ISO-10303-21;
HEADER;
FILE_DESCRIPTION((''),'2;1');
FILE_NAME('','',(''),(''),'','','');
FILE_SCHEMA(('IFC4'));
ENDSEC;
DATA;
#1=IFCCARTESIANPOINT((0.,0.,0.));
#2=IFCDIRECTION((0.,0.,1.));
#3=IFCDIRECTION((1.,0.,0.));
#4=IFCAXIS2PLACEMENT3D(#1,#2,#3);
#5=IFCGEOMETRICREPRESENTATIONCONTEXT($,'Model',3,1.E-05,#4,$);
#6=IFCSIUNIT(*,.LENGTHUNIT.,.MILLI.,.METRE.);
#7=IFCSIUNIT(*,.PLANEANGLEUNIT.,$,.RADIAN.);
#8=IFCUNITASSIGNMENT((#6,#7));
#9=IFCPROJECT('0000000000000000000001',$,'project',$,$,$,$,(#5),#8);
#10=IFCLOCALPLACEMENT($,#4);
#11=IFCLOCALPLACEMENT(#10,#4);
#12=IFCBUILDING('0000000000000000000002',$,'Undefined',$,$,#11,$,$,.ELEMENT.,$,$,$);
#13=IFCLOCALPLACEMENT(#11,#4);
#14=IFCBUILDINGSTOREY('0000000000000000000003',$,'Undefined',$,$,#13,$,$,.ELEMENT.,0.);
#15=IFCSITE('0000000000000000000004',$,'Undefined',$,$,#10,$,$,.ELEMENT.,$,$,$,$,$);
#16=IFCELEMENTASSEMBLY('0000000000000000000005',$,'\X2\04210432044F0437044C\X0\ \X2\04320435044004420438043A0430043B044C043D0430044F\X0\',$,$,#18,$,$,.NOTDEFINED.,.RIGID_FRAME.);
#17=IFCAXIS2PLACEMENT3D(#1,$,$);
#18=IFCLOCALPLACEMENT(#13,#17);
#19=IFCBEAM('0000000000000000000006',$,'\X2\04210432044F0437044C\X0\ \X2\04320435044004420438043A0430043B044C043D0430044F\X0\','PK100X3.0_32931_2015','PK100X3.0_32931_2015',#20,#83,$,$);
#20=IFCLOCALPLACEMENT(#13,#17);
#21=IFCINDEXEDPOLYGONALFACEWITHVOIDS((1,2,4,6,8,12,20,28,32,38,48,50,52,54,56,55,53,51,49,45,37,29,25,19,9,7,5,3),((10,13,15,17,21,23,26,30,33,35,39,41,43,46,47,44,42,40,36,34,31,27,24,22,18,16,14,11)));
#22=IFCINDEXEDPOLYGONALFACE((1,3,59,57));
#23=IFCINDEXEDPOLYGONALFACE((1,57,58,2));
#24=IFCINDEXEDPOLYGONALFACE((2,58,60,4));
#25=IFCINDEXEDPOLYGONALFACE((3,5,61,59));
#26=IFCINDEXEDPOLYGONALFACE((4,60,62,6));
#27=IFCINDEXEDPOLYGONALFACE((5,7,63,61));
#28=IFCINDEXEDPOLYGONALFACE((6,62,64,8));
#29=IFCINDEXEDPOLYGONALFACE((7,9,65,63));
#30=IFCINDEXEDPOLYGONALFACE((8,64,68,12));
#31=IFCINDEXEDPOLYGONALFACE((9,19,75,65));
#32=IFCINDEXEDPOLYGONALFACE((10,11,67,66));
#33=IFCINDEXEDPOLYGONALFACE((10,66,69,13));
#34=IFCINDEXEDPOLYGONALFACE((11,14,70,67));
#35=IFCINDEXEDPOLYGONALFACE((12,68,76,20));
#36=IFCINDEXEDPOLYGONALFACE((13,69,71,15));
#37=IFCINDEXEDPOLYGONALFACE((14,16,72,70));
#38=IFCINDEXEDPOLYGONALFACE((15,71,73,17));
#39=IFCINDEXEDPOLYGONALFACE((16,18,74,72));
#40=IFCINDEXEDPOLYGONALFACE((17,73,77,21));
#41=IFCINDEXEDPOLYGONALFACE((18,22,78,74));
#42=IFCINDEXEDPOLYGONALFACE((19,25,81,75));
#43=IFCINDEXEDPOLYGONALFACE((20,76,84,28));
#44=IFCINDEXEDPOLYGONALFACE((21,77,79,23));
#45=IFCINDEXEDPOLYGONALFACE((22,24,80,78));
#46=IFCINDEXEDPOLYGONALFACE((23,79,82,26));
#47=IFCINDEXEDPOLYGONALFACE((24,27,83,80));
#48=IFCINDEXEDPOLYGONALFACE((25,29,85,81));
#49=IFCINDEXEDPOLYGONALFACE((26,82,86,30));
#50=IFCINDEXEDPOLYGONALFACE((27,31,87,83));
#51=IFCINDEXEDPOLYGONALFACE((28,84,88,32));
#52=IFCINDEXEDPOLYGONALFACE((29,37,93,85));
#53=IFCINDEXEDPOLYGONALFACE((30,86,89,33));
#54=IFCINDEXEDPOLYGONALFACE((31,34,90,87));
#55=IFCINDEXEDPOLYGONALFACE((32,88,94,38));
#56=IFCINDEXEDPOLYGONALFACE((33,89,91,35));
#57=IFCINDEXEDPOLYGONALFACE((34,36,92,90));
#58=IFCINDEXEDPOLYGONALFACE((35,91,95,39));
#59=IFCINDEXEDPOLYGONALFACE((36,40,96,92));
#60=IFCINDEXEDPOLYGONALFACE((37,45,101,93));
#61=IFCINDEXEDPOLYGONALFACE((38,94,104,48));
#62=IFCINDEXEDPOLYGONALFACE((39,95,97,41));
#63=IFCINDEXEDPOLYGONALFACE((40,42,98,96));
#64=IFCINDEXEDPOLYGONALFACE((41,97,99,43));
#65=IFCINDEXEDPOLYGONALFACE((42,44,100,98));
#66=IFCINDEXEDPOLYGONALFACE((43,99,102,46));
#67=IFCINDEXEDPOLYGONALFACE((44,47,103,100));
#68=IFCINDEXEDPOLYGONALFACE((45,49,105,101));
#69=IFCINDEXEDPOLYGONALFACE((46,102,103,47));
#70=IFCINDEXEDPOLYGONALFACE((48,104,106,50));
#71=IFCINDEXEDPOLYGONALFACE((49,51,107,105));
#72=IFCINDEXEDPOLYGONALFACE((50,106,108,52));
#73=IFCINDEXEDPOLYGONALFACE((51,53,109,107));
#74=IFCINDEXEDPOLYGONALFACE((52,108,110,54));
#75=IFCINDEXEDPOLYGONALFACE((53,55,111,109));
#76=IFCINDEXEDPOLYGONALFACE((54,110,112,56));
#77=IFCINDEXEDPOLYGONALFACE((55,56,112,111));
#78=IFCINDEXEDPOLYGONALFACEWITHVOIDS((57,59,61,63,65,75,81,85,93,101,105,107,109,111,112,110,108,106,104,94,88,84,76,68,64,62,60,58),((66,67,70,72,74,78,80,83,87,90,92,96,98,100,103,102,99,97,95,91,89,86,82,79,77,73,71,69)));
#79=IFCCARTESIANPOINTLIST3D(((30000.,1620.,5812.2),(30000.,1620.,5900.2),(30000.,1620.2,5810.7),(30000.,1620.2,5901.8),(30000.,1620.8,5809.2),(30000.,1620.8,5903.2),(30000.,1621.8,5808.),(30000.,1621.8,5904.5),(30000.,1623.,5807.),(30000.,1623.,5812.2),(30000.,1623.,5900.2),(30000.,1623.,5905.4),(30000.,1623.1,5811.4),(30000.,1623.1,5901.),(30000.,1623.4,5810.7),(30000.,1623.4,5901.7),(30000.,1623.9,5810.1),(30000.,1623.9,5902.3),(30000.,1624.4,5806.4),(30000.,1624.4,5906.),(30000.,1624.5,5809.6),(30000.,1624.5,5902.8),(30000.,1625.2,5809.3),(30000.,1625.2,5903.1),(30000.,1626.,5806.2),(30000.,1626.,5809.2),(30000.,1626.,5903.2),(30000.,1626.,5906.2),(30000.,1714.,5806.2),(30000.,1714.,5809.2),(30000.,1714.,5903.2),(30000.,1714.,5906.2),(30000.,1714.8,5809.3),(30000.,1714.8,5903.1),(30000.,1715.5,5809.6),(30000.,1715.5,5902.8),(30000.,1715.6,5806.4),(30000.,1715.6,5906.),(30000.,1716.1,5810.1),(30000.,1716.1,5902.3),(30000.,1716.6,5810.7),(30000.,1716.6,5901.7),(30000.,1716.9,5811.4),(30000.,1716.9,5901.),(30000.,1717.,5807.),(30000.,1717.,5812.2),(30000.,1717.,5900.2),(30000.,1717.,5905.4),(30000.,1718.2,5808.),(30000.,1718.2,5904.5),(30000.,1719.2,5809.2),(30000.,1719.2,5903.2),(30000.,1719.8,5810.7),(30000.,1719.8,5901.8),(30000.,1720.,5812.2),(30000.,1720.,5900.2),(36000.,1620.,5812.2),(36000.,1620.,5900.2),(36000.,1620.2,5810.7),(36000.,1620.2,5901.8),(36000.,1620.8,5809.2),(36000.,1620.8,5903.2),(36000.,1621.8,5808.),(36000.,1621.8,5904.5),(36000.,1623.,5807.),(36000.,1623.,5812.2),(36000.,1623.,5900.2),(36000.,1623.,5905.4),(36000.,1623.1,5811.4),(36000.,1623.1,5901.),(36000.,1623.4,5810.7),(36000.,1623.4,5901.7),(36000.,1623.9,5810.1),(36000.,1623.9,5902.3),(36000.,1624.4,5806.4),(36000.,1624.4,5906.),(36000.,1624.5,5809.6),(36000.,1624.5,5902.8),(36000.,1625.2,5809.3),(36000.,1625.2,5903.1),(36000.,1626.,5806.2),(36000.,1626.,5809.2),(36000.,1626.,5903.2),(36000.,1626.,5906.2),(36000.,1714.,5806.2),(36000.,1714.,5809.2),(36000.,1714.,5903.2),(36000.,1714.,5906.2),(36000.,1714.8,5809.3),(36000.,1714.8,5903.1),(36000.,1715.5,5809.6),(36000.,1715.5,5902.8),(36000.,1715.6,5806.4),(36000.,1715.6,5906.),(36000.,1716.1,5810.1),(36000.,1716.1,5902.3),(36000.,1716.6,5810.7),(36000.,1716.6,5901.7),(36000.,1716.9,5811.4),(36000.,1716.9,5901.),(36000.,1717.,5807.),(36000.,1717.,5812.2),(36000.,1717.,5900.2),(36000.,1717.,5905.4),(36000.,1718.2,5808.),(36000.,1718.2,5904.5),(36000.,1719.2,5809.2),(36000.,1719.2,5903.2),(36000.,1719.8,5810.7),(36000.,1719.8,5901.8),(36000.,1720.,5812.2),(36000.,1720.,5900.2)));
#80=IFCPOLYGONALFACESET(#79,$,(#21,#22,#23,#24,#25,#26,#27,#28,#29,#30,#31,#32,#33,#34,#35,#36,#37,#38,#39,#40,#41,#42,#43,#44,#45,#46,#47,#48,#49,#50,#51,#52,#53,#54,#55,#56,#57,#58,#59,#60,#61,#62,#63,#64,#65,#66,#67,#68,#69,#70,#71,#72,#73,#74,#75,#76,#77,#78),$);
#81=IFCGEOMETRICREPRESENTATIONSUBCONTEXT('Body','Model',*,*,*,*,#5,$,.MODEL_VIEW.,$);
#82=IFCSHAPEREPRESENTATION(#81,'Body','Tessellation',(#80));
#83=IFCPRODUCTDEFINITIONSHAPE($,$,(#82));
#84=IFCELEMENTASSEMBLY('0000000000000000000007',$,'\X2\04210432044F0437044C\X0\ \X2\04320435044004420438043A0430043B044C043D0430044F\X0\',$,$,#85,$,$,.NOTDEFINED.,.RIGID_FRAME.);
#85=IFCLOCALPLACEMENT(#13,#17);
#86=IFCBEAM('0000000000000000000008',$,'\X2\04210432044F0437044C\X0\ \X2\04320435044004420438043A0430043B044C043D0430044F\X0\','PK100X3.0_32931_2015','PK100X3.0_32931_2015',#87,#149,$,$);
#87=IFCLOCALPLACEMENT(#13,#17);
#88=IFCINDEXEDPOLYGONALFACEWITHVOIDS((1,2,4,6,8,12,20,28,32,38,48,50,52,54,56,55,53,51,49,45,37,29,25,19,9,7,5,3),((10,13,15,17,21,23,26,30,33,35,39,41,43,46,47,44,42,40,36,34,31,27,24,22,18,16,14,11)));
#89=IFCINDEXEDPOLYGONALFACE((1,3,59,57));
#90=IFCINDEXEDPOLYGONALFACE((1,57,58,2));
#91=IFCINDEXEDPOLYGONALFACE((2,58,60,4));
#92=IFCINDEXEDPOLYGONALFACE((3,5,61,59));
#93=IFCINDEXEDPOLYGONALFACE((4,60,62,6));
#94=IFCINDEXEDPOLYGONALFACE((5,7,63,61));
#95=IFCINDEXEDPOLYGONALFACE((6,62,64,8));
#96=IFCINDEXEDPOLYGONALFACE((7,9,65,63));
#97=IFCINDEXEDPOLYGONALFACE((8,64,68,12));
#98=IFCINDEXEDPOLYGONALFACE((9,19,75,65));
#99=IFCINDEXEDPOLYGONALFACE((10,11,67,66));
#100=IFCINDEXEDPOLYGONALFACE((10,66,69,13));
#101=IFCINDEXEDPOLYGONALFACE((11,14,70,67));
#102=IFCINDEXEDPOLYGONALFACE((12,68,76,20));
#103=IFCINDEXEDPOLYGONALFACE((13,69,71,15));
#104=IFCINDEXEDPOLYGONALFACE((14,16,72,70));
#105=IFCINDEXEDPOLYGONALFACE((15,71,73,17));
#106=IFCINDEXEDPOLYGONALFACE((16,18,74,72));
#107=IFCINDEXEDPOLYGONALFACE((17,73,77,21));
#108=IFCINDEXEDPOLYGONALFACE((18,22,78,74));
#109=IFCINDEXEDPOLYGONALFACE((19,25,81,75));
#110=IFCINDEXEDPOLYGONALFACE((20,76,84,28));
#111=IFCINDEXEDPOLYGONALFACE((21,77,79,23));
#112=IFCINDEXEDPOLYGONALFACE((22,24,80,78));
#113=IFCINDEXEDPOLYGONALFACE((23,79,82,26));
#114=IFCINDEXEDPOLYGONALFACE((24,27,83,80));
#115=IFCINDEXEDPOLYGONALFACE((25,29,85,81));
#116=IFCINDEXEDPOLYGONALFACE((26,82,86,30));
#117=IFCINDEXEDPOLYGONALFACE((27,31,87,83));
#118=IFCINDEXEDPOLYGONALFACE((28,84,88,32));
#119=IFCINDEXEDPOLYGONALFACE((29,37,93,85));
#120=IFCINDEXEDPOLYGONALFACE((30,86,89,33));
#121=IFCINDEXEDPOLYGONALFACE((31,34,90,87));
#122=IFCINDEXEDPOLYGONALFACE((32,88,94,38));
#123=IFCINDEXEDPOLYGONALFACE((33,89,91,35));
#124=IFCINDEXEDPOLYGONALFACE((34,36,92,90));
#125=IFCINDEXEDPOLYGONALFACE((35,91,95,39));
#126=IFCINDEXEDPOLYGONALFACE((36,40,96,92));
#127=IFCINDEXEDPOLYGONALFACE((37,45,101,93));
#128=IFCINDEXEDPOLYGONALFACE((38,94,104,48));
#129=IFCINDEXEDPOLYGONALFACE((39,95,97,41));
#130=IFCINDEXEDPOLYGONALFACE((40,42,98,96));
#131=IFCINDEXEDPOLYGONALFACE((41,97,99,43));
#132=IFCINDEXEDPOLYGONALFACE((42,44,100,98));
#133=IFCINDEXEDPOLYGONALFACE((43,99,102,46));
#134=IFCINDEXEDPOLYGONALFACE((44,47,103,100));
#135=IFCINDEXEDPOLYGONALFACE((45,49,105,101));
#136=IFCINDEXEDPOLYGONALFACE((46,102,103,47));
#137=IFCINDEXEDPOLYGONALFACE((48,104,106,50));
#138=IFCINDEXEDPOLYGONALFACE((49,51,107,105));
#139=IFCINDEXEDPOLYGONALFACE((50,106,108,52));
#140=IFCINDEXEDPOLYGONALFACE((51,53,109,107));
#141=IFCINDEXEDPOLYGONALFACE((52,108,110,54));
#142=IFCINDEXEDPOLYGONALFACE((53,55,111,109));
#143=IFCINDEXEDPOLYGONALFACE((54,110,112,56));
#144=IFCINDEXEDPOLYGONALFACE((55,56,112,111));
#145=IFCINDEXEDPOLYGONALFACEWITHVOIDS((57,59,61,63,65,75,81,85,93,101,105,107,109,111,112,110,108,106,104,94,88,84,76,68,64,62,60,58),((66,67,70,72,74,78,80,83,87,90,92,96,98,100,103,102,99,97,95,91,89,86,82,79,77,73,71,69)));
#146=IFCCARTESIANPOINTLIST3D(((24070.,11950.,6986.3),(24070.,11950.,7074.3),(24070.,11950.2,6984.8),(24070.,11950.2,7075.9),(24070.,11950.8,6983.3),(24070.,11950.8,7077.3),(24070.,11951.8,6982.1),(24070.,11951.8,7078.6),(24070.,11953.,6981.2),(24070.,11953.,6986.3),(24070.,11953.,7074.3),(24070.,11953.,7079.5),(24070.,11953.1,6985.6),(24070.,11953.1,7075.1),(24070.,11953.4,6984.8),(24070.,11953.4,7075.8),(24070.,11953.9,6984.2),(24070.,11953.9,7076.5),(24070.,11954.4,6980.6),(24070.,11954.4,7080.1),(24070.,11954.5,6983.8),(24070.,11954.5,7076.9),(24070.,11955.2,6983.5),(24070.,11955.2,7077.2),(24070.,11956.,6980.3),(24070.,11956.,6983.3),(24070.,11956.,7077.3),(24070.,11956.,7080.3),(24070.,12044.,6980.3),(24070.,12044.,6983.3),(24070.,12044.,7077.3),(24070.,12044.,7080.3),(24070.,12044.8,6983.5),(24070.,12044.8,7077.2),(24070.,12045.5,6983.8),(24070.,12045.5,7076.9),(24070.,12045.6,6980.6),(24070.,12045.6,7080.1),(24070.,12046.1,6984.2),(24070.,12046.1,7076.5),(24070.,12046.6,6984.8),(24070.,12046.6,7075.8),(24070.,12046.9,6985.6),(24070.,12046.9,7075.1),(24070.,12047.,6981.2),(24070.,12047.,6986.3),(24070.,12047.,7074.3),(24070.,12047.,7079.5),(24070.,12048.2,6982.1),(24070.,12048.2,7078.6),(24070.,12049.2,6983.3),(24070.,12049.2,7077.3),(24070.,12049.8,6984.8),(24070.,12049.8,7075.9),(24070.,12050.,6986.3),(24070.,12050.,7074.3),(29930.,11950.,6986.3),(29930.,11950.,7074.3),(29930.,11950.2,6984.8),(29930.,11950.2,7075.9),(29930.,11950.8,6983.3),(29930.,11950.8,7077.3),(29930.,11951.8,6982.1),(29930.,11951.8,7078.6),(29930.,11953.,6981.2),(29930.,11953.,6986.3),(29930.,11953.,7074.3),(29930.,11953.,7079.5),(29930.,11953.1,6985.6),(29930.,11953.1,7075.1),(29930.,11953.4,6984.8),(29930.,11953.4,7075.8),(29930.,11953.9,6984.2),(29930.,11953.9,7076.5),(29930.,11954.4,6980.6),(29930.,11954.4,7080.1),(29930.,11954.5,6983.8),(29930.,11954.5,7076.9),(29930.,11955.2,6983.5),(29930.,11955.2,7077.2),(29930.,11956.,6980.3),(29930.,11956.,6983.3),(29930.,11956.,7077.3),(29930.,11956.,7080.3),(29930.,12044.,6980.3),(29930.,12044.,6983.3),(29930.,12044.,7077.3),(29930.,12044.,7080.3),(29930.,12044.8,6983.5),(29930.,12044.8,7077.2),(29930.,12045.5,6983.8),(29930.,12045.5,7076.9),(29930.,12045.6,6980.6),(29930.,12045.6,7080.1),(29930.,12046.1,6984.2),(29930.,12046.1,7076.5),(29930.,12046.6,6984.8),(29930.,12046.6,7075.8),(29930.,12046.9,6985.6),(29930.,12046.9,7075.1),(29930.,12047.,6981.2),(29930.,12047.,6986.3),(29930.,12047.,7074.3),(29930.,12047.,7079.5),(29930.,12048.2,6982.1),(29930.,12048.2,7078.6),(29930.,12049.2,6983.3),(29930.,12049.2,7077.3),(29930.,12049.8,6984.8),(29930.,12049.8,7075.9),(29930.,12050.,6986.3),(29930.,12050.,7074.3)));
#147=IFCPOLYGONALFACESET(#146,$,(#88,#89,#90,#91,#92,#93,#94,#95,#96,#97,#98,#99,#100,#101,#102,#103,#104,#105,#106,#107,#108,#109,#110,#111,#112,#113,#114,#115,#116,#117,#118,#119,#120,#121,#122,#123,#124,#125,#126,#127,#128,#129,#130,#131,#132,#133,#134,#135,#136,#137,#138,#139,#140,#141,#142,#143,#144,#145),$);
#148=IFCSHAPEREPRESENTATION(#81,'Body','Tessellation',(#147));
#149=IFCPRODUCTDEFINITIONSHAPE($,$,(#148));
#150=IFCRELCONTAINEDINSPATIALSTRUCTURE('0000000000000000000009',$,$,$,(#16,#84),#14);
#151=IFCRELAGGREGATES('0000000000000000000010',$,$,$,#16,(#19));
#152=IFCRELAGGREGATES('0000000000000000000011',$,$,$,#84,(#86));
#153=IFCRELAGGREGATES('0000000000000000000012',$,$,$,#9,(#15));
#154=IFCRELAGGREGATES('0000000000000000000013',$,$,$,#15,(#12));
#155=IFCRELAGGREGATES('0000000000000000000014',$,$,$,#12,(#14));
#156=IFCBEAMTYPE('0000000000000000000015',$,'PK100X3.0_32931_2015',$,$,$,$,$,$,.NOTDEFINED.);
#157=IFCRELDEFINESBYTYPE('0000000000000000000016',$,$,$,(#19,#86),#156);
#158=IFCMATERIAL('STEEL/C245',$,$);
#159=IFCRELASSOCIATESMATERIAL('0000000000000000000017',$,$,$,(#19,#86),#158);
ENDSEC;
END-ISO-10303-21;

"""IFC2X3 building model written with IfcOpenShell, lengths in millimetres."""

from ifc_helpers import new_model, si_unit, frame, origin_with_axes, origin_2d_with_axis, place, context, subcontext, project, spatial, hollow_rectangle, extrude, material, type_object, element, aggregate, save


model = new_model("IFC2X3")

# Units and contexts
model_context = context("Model", 3, precision=1e-05, world=origin_with_axes())
body_context = subcontext(model_context, "Body", "Model", "MODEL_VIEW")
ifc_project = project(units=[si_unit("LENGTHUNIT", "METRE", prefix="MILLI"), si_unit("PLANEANGLEUNIT", "RADIAN")], contexts=[model_context])

# Site, building, storey
site_placement = place(None, origin_with_axes())
site = spatial("IfcSite", under=ifc_project, at=site_placement, Name="Undefined", CompositionType="ELEMENT")
building_placement = place(site_placement, origin_with_axes())
building = spatial("IfcBuilding", under=site, at=building_placement, Name="Undefined", CompositionType="ELEMENT")
storey_placement = place(building_placement, origin_with_axes())
storey = spatial("IfcBuildingStorey", under=building, at=storey_placement, Name="Undefined", CompositionType="ELEMENT", Elevation=0.0)

# Element assemblies, beams
assembly_1_placement = place(storey_placement, origin_with_axes())
assembly_1 = element("IfcElementAssembly", 1, at=assembly_1_placement, inside=storey, Name="Связь вертикальная", AssemblyPlace="NOTDEFINED", PredefinedType="RIGID_FRAME")
ifc_material_1 = material(Name="STEEL/C245")
beam_type_1 = type_object("IfcBeamType", Name="PK100X3.0_32931_2015", PredefinedType="NOTDEFINED")
beam_1_placement = place(assembly_1_placement, frame((30000.0, 1670.0, 5856.2), z_axis=(0.0, 0.0, 1.0), x_axis=(1.0, 0.0, 0.0)))
beam_1 = element("IfcBeam", 2, at=beam_1_placement, type_object=beam_type_1, material=ifc_material_1, Name="Связь вертикальная", Description="PK100X3.0_32931_2015", ObjectType="PK100X3.0_32931_2015", context=body_context, shape_type="SweptSolid", body=[
    extrude(hollow_rectangle(XDim=100.0, YDim=100.0, WallThickness=3.0, InnerFilletRadius=3.0, OuterFilletRadius=6.0, at=origin_2d_with_axis()), frame((6000.0, 0.0, 0.0), z_axis=(-1.0, 0.0, 0.0), x_axis=(0.0, -1.0, 0.0)), (0.0, 0.0, 1.0), 6000.0),
])
aggregate(assembly_1, [beam_1])
assembly_2_placement = place(storey_placement, origin_with_axes())
assembly_2 = element("IfcElementAssembly", 3, at=assembly_2_placement, inside=storey, Name="Связь вертикальная", AssemblyPlace="NOTDEFINED", PredefinedType="RIGID_FRAME")
beam_2_placement = place(assembly_2_placement, frame((24070.0, 12000.0, 7030.3), z_axis=(0.0, 0.0, 1.0), x_axis=(1.0, 0.0, 0.0)))
beam_2 = element("IfcBeam", 4, at=beam_2_placement, type_object=beam_type_1, material=ifc_material_1, Name="Связь вертикальная", Description="PK100X3.0_32931_2015", ObjectType="PK100X3.0_32931_2015", context=body_context, shape_type="SweptSolid", body=[
    extrude(hollow_rectangle(XDim=100.0, YDim=100.0, WallThickness=3.0, InnerFilletRadius=3.0, OuterFilletRadius=6.0, at=origin_2d_with_axis()), frame((5860.0, 0.0, 0.0), z_axis=(-1.0, 0.0, 0.0), x_axis=(0.0, -1.0, 0.0)), (0.0, 0.0, 1.0), 5860.0),
])
aggregate(assembly_2, [beam_2])

save(model, "model.ifc")
